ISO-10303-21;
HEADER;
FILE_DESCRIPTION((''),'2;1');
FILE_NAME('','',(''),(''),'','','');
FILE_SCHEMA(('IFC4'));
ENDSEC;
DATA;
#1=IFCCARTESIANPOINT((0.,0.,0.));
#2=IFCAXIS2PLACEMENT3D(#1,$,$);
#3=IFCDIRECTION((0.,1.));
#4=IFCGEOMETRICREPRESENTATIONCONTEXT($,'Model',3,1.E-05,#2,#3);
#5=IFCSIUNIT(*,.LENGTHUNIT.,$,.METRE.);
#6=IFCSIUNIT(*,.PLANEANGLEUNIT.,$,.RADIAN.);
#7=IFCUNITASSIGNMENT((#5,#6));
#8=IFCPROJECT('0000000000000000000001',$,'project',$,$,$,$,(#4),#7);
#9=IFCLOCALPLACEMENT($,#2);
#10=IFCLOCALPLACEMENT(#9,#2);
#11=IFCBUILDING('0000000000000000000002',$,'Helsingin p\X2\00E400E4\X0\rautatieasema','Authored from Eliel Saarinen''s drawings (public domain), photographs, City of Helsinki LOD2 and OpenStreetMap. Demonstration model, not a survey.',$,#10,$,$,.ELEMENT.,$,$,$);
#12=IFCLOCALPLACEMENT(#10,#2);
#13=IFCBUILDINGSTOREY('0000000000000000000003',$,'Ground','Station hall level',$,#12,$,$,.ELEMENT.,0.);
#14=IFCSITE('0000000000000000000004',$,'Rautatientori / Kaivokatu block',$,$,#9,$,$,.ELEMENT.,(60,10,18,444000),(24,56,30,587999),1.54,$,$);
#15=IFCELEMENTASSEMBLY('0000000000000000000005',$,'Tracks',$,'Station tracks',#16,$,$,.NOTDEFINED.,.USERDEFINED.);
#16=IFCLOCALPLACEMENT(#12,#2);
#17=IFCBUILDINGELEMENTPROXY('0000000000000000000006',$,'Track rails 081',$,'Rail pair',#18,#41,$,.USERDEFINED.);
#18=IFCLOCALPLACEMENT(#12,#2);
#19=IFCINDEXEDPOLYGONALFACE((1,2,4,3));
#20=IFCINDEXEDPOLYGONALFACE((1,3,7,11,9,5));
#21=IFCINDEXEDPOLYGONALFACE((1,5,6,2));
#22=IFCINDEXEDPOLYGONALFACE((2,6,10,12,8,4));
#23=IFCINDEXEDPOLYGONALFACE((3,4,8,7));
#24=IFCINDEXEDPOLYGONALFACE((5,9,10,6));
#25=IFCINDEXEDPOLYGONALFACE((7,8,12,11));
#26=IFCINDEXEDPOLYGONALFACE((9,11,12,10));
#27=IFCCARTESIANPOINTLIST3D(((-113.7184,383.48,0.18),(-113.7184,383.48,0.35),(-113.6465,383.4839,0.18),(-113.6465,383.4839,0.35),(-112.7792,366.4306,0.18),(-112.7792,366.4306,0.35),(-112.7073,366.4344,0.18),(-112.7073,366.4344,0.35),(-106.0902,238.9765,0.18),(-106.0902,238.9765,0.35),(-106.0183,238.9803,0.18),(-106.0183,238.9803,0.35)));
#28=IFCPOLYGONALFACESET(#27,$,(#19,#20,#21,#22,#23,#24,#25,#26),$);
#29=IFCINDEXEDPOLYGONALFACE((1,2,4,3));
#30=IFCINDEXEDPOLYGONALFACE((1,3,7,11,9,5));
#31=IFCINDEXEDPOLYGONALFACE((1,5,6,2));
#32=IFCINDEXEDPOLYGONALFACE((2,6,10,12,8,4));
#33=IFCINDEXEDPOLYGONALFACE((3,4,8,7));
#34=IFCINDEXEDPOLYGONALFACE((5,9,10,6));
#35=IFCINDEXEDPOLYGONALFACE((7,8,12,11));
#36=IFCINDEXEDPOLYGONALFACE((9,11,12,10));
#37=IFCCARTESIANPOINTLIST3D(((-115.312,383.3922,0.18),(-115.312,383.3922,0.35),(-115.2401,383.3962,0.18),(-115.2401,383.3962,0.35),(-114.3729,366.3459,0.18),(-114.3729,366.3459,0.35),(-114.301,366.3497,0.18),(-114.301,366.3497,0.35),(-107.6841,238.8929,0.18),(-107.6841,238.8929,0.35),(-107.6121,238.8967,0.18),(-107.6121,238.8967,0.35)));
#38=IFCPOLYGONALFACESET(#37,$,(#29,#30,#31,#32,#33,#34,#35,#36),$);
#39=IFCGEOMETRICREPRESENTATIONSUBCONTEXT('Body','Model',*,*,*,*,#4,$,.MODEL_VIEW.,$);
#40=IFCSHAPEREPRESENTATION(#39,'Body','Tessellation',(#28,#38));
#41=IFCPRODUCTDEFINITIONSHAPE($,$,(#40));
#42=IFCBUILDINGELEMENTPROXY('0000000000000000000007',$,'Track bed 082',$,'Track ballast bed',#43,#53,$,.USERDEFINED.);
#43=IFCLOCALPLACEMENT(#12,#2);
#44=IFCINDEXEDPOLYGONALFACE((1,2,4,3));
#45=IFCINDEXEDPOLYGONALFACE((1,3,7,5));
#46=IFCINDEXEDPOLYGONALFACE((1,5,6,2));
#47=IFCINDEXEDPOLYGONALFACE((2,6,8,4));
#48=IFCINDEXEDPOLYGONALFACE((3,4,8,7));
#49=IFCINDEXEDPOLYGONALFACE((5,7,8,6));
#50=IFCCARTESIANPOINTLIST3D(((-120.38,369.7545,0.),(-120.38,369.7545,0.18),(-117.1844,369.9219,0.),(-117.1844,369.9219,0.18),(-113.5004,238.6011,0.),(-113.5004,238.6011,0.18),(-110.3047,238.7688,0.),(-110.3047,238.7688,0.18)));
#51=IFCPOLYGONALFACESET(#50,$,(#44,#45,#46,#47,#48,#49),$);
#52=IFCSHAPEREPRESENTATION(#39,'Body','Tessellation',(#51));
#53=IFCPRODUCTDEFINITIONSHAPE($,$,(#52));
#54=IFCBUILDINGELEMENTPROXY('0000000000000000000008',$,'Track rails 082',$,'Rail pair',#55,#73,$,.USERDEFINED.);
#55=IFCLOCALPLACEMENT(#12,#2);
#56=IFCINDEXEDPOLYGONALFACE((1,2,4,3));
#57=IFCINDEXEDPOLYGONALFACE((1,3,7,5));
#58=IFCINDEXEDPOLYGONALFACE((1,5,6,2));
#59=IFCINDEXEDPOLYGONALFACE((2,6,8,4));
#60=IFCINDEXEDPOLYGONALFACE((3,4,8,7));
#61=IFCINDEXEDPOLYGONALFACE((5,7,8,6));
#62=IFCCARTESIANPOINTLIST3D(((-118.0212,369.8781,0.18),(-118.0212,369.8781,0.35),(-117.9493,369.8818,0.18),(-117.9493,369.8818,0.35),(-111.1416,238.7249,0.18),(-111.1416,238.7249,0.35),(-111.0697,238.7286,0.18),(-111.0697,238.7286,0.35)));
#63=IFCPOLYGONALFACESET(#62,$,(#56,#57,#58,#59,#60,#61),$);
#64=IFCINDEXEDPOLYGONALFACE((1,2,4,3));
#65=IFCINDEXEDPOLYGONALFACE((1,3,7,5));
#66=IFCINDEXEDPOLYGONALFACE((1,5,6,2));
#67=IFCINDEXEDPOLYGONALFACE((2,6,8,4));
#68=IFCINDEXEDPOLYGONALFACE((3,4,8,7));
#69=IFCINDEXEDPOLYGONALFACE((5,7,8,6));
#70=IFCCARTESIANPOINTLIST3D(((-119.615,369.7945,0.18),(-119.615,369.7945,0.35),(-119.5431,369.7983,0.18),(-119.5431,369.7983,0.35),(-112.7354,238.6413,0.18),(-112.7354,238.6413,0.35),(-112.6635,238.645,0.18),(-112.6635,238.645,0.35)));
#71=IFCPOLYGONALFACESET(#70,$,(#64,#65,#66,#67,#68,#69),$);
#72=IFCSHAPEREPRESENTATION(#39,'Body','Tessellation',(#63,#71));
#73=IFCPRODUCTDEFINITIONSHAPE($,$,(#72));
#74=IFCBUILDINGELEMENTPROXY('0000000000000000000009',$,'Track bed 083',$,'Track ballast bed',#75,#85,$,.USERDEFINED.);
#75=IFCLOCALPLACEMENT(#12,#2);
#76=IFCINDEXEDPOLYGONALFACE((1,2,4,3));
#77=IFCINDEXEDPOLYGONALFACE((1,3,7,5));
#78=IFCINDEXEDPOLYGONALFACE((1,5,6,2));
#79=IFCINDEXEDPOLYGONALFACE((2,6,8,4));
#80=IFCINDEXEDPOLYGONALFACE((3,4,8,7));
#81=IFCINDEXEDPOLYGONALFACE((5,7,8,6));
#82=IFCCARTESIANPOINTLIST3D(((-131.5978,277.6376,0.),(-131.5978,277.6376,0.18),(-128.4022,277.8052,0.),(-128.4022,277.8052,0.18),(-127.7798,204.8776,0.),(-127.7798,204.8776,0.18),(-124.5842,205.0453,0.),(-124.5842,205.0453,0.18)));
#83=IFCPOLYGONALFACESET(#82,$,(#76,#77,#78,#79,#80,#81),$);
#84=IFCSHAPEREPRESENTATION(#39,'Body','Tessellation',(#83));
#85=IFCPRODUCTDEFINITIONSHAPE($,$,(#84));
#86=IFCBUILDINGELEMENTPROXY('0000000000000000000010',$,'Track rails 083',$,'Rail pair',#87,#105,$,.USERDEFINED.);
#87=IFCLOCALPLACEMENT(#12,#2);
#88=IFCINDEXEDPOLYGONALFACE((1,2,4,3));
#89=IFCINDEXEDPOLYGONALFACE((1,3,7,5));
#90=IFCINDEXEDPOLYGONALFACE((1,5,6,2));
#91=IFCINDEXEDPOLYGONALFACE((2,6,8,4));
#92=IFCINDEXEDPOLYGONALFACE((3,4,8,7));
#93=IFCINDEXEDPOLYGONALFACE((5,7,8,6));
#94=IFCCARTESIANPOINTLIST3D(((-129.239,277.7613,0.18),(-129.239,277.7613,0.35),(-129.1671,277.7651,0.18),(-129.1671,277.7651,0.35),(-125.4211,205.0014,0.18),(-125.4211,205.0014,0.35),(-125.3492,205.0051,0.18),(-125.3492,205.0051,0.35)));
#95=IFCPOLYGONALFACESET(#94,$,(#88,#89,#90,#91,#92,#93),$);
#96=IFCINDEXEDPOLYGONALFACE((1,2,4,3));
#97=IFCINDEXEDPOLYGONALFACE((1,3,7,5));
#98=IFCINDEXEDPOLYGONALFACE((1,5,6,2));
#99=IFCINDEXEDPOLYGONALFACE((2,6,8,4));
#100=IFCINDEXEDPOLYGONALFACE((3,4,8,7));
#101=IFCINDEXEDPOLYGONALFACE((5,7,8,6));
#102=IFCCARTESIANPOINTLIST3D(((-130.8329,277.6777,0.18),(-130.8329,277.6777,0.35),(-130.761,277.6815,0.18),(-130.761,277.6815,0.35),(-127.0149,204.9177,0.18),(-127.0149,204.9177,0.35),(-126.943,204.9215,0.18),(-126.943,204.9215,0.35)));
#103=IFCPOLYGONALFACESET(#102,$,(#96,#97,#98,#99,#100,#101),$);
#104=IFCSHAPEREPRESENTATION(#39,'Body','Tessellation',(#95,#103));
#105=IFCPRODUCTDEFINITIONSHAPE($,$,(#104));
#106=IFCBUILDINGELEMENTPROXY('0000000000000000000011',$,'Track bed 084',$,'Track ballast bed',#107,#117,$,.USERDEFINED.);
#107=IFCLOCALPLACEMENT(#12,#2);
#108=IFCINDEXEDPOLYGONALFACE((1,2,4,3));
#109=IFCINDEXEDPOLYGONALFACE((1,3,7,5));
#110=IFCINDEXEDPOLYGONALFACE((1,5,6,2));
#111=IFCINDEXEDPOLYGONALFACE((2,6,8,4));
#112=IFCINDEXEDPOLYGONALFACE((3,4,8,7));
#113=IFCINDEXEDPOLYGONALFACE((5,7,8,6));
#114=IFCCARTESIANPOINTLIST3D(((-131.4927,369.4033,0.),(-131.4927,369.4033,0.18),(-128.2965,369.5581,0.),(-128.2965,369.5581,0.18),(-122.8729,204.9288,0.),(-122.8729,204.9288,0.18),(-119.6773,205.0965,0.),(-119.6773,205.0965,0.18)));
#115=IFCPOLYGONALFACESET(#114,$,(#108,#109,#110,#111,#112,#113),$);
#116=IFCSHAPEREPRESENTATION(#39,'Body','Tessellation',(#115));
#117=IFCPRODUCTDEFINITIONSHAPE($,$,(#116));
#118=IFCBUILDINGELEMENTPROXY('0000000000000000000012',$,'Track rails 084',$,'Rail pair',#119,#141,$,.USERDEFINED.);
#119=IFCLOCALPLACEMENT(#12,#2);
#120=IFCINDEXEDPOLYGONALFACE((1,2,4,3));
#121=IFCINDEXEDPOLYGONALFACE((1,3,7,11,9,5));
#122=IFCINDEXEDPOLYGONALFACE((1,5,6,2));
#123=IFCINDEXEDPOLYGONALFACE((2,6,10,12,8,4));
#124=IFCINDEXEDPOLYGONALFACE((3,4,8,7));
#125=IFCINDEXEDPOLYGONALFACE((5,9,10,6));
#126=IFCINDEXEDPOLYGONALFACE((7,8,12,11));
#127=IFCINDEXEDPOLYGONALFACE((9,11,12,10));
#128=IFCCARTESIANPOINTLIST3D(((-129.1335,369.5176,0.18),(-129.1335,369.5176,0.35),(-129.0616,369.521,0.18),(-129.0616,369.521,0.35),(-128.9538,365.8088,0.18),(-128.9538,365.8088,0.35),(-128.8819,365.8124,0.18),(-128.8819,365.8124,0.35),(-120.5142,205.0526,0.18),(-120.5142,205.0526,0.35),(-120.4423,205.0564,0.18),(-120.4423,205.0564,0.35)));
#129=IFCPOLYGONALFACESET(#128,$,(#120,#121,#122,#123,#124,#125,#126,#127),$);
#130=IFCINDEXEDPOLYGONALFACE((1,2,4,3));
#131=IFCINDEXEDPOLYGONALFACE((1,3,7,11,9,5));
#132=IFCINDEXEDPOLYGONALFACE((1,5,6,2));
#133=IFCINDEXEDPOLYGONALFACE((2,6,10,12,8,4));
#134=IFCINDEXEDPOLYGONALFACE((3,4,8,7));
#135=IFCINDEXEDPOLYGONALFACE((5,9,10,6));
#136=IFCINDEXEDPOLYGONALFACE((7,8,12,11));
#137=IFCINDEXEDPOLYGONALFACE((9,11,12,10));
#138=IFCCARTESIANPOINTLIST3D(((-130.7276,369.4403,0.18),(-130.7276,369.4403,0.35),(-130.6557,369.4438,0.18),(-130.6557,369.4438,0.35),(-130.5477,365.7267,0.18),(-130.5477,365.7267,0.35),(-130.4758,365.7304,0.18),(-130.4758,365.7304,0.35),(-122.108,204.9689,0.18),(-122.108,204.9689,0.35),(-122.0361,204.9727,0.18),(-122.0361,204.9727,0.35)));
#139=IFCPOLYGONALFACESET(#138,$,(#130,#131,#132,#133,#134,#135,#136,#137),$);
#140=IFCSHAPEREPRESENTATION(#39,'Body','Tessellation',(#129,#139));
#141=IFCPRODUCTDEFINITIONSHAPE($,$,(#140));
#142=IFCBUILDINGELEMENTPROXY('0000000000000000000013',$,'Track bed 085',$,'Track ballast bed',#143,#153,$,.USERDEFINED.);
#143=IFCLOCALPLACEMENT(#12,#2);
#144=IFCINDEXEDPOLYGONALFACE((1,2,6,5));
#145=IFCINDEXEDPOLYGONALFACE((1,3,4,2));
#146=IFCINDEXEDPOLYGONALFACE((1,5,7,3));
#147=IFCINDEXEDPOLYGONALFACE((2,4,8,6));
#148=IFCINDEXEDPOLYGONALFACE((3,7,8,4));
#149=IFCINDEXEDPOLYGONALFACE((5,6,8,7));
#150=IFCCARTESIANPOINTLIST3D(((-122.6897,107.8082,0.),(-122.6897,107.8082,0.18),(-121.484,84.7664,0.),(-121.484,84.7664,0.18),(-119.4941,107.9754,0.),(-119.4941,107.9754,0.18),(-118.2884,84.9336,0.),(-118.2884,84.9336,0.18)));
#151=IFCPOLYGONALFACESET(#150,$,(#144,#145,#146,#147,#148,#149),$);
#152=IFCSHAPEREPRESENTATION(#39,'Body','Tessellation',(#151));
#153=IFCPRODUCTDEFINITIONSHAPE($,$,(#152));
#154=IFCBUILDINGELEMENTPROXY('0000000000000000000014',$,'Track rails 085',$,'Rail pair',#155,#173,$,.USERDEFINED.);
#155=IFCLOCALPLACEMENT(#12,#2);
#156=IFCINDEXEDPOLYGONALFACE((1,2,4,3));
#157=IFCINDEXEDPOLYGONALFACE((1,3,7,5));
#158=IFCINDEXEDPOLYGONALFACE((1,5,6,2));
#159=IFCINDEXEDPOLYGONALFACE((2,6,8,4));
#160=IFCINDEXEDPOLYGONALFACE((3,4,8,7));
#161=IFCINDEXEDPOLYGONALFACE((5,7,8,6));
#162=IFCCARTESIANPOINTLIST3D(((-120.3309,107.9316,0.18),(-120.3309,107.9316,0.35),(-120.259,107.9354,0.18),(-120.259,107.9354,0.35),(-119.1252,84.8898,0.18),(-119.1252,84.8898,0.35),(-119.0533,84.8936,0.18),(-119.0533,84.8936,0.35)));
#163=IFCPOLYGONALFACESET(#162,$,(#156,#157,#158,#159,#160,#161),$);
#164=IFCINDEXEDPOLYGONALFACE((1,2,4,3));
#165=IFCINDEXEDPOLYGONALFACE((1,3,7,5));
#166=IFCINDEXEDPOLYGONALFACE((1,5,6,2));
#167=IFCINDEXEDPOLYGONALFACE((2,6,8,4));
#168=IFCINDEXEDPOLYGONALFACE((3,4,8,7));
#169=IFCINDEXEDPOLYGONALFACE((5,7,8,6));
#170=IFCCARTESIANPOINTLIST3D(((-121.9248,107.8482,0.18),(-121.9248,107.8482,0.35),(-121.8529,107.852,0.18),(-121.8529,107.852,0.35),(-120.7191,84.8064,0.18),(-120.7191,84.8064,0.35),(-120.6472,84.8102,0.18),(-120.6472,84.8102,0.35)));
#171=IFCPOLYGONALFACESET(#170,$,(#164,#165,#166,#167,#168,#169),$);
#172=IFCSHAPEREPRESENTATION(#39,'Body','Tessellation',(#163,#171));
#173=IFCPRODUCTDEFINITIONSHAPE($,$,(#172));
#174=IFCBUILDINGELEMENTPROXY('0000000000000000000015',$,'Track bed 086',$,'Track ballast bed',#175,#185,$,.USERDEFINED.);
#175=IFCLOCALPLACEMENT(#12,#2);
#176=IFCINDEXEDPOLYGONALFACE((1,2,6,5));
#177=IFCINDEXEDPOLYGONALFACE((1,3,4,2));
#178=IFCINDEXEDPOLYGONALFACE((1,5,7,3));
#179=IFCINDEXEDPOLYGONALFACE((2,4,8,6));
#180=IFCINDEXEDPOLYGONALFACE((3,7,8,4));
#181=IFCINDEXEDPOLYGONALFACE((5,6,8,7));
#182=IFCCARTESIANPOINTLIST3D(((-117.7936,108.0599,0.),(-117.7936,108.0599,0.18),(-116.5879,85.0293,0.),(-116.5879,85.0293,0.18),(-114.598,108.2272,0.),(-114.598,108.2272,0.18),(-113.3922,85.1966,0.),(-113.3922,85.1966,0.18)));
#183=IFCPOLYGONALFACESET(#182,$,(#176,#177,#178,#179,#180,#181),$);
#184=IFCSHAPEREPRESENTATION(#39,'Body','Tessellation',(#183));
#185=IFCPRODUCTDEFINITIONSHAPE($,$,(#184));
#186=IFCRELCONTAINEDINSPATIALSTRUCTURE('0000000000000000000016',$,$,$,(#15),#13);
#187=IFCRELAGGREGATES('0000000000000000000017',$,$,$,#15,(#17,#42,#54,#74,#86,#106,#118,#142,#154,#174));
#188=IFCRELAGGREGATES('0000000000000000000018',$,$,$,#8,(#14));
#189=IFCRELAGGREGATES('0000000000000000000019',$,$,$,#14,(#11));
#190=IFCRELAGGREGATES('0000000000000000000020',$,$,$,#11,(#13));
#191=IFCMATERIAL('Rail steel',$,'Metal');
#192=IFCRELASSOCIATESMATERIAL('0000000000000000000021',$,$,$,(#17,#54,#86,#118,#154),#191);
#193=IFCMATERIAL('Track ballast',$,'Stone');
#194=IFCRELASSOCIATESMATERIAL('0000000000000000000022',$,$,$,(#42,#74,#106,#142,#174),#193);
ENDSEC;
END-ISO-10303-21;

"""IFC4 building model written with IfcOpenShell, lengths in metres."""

from ifc_helpers import new_model, si_unit, direction, frame, origin, place, context, subcontext, project, spatial, polyline, outline, extrude, material, element, aggregate, save


model = new_model("IFC4")

# Units and contexts
model_context = context("Model", 3, precision=1e-05, world=origin(), true_north=direction((0.0, 1.0)))
body_context = subcontext(model_context, "Body", "Model", "MODEL_VIEW")
ifc_project = project(units=[si_unit("LENGTHUNIT", "METRE"), si_unit("PLANEANGLEUNIT", "RADIAN")], contexts=[model_context])

# Site, building, storey
site_placement = place(None, origin())
site = spatial("IfcSite", under=ifc_project, at=site_placement, Name="Rautatientori / Kaivokatu block", CompositionType="ELEMENT", RefLatitude=(60, 10, 18, 444000), RefLongitude=(24, 56, 30, 587999), RefElevation=1.54)
building_placement = place(site_placement, origin())
building = spatial("IfcBuilding", under=site, at=building_placement, Name="Helsingin päärautatieasema", Description="Authored from Eliel Saarinen's drawings (public domain), photographs, City of Helsinki LOD2 and OpenStreetMap. Demonstration model, not a survey.", CompositionType="ELEMENT")
storey_placement = place(building_placement, origin())
storey = spatial("IfcBuildingStorey", under=building, at=storey_placement, Name="Ground", Description="Station hall level", CompositionType="ELEMENT", Elevation=0.0)

# Element assembly, building element proxies
assembly_placement = place(building_placement, origin())
assembly = element("IfcElementAssembly", 1, at=assembly_placement, inside=storey, Name="Tracks", ObjectType="Station tracks", AssemblyPlace="NOTDEFINED", PredefinedType="USERDEFINED")
ifc_material_1 = material(Name="Track ballast", Category="Stone")
ifc_material_2 = material(Name="Rail steel", Category="Metal")
proxy_1_placement = place(building_placement, origin())
proxy_1 = element("IfcBuildingElementProxy", 2, at=proxy_1_placement, material=ifc_material_2, Name="Track rails 081", ObjectType="Rail pair", PredefinedType="USERDEFINED", context=body_context, shape_type="SweptSolid", body=[
    extrude(outline(polyline([(-112.7792, 366.4306), (-113.7184, 383.48), (-113.6465, 383.4839), (-112.7073, 366.4344), (-106.0183, 238.9803), (-106.0902, 238.9765), (-112.7792, 366.4306)])), frame((0.0, 0.0, 0.18)), (0.0, 0.0, 1.0), 0.17),
    extrude(outline(polyline([(-114.3729, 366.3459), (-115.312, 383.3922), (-115.2401, 383.3962), (-114.301, 366.3497), (-107.6121, 238.8967), (-107.6841, 238.8929), (-114.3729, 366.3459)])), frame((0.0, 0.0, 0.18)), (0.0, 0.0, 1.0), 0.17),
])
proxy_2_placement = place(building_placement, origin())
proxy_2 = element("IfcBuildingElementProxy", 3, at=proxy_2_placement, material=ifc_material_1, Name="Track bed 082", ObjectType="Track ballast bed", PredefinedType="USERDEFINED", context=body_context, shape_type="SweptSolid", body=[
    extrude(outline(polyline([(-113.5004, 238.6011), (-120.38, 369.7545), (-117.1844, 369.9219), (-110.3047, 238.7688), (-113.5004, 238.6011)])), origin(), (0.0, 0.0, 1.0), 0.18),
])
proxy_3_placement = place(building_placement, origin())
proxy_3 = element("IfcBuildingElementProxy", 4, at=proxy_3_placement, material=ifc_material_2, Name="Track rails 082", ObjectType="Rail pair", PredefinedType="USERDEFINED", context=body_context, shape_type="SweptSolid", body=[
    extrude(outline(polyline([(-111.1416, 238.7249), (-118.0212, 369.8781), (-117.9493, 369.8818), (-111.0697, 238.7286), (-111.1416, 238.7249)])), frame((0.0, 0.0, 0.18)), (0.0, 0.0, 1.0), 0.17),
    extrude(outline(polyline([(-112.7354, 238.6413), (-119.615, 369.7945), (-119.5431, 369.7983), (-112.6635, 238.645), (-112.7354, 238.6413)])), frame((0.0, 0.0, 0.18)), (0.0, 0.0, 1.0), 0.17),
])
proxy_4_placement = place(building_placement, origin())
proxy_4 = element("IfcBuildingElementProxy", 5, at=proxy_4_placement, material=ifc_material_1, Name="Track bed 083", ObjectType="Track ballast bed", PredefinedType="USERDEFINED", context=body_context, shape_type="SweptSolid", body=[
    extrude(outline(polyline([(-131.5978, 277.6376), (-128.4022, 277.8052), (-124.5842, 205.0453), (-127.7798, 204.8776), (-131.5978, 277.6376)])), origin(), (0.0, 0.0, 1.0), 0.18),
])
proxy_5_placement = place(building_placement, origin())
proxy_5 = element("IfcBuildingElementProxy", 6, at=proxy_5_placement, material=ifc_material_2, Name="Track rails 083", ObjectType="Rail pair", PredefinedType="USERDEFINED", context=body_context, shape_type="SweptSolid", body=[
    extrude(outline(polyline([(-129.239, 277.7613), (-129.1671, 277.7651), (-125.3492, 205.0051), (-125.4211, 205.0014), (-129.239, 277.7613)])), frame((0.0, 0.0, 0.18)), (0.0, 0.0, 1.0), 0.17),
    extrude(outline(polyline([(-130.8329, 277.6777), (-130.761, 277.6815), (-126.943, 204.9215), (-127.0149, 204.9177), (-130.8329, 277.6777)])), frame((0.0, 0.0, 0.18)), (0.0, 0.0, 1.0), 0.17),
])
proxy_6_placement = place(building_placement, origin())
proxy_6 = element("IfcBuildingElementProxy", 7, at=proxy_6_placement, material=ifc_material_1, Name="Track bed 084", ObjectType="Track ballast bed", PredefinedType="USERDEFINED", context=body_context, shape_type="SweptSolid", body=[
    extrude(outline(polyline([(-122.8729, 204.9288), (-131.4927, 369.4033), (-128.2965, 369.5581), (-119.6773, 205.0965), (-122.8729, 204.9288)])), origin(), (0.0, 0.0, 1.0), 0.18),
])
proxy_7_placement = place(building_placement, origin())
proxy_7 = element("IfcBuildingElementProxy", 8, at=proxy_7_placement, material=ifc_material_2, Name="Track rails 084", ObjectType="Rail pair", PredefinedType="USERDEFINED", context=body_context, shape_type="SweptSolid", body=[
    extrude(outline(polyline([(-128.9538, 365.8088), (-129.1335, 369.5176), (-129.0616, 369.521), (-128.8819, 365.8124), (-120.4423, 205.0564), (-120.5142, 205.0526), (-128.9538, 365.8088)])), frame((0.0, 0.0, 0.18)), (0.0, 0.0, 1.0), 0.17),
    extrude(outline(polyline([(-130.5477, 365.7267), (-130.7276, 369.4403), (-130.6557, 369.4438), (-130.4758, 365.7304), (-122.0361, 204.9727), (-122.108, 204.9689), (-130.5477, 365.7267)])), frame((0.0, 0.0, 0.18)), (0.0, 0.0, 1.0), 0.17),
])
proxy_8_placement = place(building_placement, origin())
proxy_8 = element("IfcBuildingElementProxy", 9, at=proxy_8_placement, material=ifc_material_1, Name="Track bed 085", ObjectType="Track ballast bed", PredefinedType="USERDEFINED", context=body_context, shape_type="SweptSolid", body=[
    extrude(outline(polyline([(-122.6897, 107.8082), (-119.4941, 107.9754), (-118.2884, 84.9336), (-121.484, 84.7664), (-122.6897, 107.8082)])), origin(), (0.0, 0.0, 1.0), 0.18),
])
proxy_9_placement = place(building_placement, origin())
proxy_9 = element("IfcBuildingElementProxy", 10, at=proxy_9_placement, material=ifc_material_2, Name="Track rails 085", ObjectType="Rail pair", PredefinedType="USERDEFINED", context=body_context, shape_type="SweptSolid", body=[
    extrude(outline(polyline([(-120.3309, 107.9316), (-120.259, 107.9354), (-119.0533, 84.8936), (-119.1252, 84.8898), (-120.3309, 107.9316)])), frame((0.0, 0.0, 0.18)), (0.0, 0.0, 1.0), 0.17),
    extrude(outline(polyline([(-121.9248, 107.8482), (-121.8529, 107.852), (-120.6472, 84.8102), (-120.7191, 84.8064), (-121.9248, 107.8482)])), frame((0.0, 0.0, 0.18)), (0.0, 0.0, 1.0), 0.17),
])
proxy_10_placement = place(building_placement, origin())
proxy_10 = element("IfcBuildingElementProxy", 11, at=proxy_10_placement, material=ifc_material_1, Name="Track bed 086", ObjectType="Track ballast bed", PredefinedType="USERDEFINED", context=body_context, shape_type="SweptSolid", body=[
    extrude(outline(polyline([(-117.7936, 108.0599), (-114.598, 108.2272), (-113.3922, 85.1966), (-116.5879, 85.0293), (-117.7936, 108.0599)])), origin(), (0.0, 0.0, 1.0), 0.18),
])
aggregate(assembly, [proxy_1, proxy_2, proxy_3, proxy_4, proxy_5, proxy_6, proxy_7, proxy_8, proxy_9, proxy_10])

save(model, "model.ifc")
